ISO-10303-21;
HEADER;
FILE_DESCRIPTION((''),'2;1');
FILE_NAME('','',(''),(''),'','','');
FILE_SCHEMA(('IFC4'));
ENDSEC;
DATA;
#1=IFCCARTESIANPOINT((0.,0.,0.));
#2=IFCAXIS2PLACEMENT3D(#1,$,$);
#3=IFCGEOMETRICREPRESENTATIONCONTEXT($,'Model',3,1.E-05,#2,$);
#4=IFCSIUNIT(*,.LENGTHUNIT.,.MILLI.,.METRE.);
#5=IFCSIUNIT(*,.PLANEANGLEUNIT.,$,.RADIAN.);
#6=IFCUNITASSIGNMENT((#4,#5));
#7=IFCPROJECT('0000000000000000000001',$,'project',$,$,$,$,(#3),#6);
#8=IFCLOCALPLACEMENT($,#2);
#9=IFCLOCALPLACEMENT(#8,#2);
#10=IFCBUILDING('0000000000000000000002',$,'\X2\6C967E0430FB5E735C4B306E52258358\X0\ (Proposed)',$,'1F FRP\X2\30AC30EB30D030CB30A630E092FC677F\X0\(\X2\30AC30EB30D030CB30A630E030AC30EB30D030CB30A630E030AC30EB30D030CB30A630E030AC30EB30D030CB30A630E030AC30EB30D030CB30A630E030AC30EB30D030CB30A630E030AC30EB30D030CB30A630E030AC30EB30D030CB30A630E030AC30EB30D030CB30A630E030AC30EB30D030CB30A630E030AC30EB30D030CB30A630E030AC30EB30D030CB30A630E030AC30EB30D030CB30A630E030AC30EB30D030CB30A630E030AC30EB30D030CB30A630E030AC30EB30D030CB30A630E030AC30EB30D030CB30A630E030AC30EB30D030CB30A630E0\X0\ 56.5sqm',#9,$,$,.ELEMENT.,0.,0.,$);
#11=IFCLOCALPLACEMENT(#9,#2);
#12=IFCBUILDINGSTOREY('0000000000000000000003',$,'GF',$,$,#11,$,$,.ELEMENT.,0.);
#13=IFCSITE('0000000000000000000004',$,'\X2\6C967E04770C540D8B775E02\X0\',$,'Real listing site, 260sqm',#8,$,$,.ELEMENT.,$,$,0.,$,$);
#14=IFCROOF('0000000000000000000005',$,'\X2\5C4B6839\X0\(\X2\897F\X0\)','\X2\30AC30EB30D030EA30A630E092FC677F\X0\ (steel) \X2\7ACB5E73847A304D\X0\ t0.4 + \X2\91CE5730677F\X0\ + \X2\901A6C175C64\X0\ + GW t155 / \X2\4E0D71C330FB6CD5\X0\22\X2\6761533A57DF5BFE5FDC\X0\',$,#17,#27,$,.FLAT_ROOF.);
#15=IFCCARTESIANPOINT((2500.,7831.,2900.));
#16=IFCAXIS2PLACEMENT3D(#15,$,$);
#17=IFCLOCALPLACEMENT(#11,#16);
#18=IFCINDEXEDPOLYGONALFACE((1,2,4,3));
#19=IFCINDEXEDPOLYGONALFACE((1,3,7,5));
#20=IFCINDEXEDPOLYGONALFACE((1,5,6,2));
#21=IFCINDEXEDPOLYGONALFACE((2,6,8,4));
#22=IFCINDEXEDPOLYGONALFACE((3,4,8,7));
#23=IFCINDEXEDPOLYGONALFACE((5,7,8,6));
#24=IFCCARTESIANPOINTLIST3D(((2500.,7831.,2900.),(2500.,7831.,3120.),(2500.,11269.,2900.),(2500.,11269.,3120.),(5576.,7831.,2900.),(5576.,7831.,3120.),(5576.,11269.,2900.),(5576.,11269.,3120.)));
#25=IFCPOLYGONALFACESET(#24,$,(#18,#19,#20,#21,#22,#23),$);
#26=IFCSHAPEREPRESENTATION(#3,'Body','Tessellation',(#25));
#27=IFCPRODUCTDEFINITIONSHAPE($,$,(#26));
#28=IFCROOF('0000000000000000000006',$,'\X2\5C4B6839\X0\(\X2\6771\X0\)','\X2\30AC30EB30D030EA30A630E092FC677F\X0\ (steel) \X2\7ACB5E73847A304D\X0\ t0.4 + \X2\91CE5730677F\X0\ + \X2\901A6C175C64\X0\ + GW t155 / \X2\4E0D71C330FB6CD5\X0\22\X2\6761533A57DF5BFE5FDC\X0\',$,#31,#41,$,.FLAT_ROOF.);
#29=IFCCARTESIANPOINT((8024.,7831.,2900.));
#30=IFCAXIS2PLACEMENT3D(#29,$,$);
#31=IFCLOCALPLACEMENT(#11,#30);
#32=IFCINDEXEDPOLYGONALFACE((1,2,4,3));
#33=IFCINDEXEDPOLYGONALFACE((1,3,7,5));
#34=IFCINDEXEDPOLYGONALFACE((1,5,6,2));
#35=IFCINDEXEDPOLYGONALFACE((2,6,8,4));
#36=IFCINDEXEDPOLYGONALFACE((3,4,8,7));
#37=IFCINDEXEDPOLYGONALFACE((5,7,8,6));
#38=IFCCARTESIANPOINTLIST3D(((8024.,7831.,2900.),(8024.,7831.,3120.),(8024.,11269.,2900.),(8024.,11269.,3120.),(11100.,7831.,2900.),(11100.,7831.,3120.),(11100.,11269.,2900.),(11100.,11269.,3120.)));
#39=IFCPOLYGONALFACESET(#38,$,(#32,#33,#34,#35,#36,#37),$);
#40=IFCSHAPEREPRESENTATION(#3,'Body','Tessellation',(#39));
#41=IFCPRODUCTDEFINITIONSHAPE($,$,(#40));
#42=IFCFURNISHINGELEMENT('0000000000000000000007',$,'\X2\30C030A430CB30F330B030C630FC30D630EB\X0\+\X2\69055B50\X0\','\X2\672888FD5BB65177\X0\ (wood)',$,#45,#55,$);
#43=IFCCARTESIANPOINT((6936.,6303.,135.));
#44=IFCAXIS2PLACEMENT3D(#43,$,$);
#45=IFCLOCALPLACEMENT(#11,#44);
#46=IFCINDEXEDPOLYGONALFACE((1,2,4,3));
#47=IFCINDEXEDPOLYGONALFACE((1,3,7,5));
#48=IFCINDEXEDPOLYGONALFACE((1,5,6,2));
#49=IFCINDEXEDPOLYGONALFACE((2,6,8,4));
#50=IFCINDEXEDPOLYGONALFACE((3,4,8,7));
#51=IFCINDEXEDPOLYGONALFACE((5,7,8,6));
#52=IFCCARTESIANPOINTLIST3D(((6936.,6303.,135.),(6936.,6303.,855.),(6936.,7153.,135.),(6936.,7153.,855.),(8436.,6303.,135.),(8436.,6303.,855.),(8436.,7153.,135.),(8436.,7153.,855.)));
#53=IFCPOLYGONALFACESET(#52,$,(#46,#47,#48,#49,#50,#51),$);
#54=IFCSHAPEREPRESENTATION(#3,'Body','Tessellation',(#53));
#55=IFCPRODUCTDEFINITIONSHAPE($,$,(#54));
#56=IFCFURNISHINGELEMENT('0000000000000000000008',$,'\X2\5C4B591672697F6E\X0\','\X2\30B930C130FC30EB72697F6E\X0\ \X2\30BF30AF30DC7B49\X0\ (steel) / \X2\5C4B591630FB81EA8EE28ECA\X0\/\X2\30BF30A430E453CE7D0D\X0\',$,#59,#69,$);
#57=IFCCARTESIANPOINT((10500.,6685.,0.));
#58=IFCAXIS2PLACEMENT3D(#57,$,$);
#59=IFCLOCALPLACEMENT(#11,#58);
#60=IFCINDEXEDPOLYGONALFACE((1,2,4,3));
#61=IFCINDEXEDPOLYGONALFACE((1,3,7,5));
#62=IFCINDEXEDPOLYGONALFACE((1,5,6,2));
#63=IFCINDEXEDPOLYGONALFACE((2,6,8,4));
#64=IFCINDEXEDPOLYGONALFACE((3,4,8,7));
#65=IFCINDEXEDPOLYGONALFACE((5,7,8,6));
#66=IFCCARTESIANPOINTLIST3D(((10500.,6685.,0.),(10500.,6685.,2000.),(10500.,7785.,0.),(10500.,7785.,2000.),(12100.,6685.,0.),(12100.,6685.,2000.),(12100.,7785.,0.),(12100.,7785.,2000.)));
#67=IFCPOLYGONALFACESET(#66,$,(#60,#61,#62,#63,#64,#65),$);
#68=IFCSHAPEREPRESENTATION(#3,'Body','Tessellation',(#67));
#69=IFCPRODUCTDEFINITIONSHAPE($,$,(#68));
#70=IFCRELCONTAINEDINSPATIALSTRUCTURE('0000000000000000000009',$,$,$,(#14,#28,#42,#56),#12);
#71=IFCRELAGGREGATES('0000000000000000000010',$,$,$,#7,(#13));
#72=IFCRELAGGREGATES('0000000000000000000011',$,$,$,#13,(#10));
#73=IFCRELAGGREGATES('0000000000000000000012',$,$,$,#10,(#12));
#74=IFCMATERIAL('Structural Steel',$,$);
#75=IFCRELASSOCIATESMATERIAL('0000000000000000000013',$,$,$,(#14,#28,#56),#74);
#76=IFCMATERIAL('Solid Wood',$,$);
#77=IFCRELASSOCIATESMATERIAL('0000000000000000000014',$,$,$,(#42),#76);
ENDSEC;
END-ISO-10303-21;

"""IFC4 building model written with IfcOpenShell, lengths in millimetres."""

from ifc_helpers import new_model, si_unit, frame, frame_2d, origin, place, context, project, spatial, rectangle, extrude, material, element, save


model = new_model("IFC4")

# Units and contexts
model_context = context("Model", 3, precision=1e-05, world=origin())
ifc_project = project(units=[si_unit("LENGTHUNIT", "METRE", prefix="MILLI"), si_unit("PLANEANGLEUNIT", "RADIAN")], contexts=[model_context])

# Site, building, storey
site_placement = place(None, origin())
site = spatial("IfcSite", under=ifc_project, at=site_placement, Name="沖縄県名護市", ObjectType="Real listing site, 260sqm", CompositionType="ELEMENT", RefElevation=0.0)
building_placement = place(site_placement, origin())
building = spatial("IfcBuilding", under=site, at=building_placement, Name="沖縄・平屋の別荘 (Proposed)", ObjectType="1F FRPガルバニウム鋼板(ガルバニウムガルバニウムガルバニウムガルバニウムガルバニウムガルバニウムガルバニウムガルバニウムガルバニウムガルバニウムガルバニウムガルバニウムガルバニウムガルバニウムガルバニウムガルバニウムガルバニウムガルバニウム 56.5sqm", CompositionType="ELEMENT", ElevationOfRefHeight=0.0, ElevationOfTerrain=0.0)
storey_placement = place(building_placement, origin())
storey = spatial("IfcBuildingStorey", under=building, at=storey_placement, Name="GF", CompositionType="ELEMENT", Elevation=0.0)

# Shared definitions
ifc_material_1 = material(Name="Solid Wood")

# Roofs
ifc_material_2 = material(Name="Structural Steel")
roof_1_placement = place(storey_placement, frame((2500.0, 7831.0, 2900.0)))
element("IfcRoof", 1, at=roof_1_placement, inside=storey, material=ifc_material_2, Name="屋根(西)", Description="ガルバリウム鋼板 (steel) 立平葺き t0.4 + 野地板 + 通気層 + GW t155 / 不燃・法22条区域対応", PredefinedType="FLAT_ROOF", context=model_context, shape_type="SweptSolid", body=[
    extrude(rectangle(XDim=3076.0, YDim=3438.0, at=frame_2d((1538.0, 1719.0))), frame((2500.0, 7831.0, 2900.0)), (0.0, 0.0, 1.0), 220.0),
])
roof_2_placement = place(storey_placement, frame((8024.0, 7831.0, 2900.0)))
element("IfcRoof", 2, at=roof_2_placement, inside=storey, material=ifc_material_2, Name="屋根(東)", Description="ガルバリウム鋼板 (steel) 立平葺き t0.4 + 野地板 + 通気層 + GW t155 / 不燃・法22条区域対応", PredefinedType="FLAT_ROOF", context=model_context, shape_type="SweptSolid", body=[
    extrude(rectangle(XDim=3076.0, YDim=3438.0, at=frame_2d((1538.0, 1719.0))), frame((8024.0, 7831.0, 2900.0)), (0.0, 0.0, 1.0), 220.0),
])

# Furnishing elements
furnishing_1_placement = place(storey_placement, frame((6936.0, 6303.0, 135.0)))
element("IfcFurnishingElement", 3, at=furnishing_1_placement, inside=storey, material=ifc_material_1, Name="ダイニングテーブル+椅子", Description="木製家具 (wood)", context=model_context, shape_type="SweptSolid", body=[
    extrude(rectangle(XDim=1500.0, YDim=850.0, at=frame_2d((750.0, 425.0))), frame((6936.0, 6303.0, 135.0)), (0.0, 0.0, 1.0), 720.0),
])
furnishing_2_placement = place(storey_placement, frame((10500.0, 6685.0, 0.0)))
element("IfcFurnishingElement", 4, at=furnishing_2_placement, inside=storey, material=ifc_material_2, Name="屋外物置", Description="スチール物置 タクボ等 (steel) / 屋外・自転車/タイヤ収納", context=model_context, shape_type="SweptSolid", body=[
    extrude(rectangle(XDim=1600.0, YDim=1100.0, at=frame_2d((800.0, 550.0))), frame((10500.0, 6685.0, 0.0)), (0.0, 0.0, 1.0), 2000.0),
])

save(model, "model.ifc")
